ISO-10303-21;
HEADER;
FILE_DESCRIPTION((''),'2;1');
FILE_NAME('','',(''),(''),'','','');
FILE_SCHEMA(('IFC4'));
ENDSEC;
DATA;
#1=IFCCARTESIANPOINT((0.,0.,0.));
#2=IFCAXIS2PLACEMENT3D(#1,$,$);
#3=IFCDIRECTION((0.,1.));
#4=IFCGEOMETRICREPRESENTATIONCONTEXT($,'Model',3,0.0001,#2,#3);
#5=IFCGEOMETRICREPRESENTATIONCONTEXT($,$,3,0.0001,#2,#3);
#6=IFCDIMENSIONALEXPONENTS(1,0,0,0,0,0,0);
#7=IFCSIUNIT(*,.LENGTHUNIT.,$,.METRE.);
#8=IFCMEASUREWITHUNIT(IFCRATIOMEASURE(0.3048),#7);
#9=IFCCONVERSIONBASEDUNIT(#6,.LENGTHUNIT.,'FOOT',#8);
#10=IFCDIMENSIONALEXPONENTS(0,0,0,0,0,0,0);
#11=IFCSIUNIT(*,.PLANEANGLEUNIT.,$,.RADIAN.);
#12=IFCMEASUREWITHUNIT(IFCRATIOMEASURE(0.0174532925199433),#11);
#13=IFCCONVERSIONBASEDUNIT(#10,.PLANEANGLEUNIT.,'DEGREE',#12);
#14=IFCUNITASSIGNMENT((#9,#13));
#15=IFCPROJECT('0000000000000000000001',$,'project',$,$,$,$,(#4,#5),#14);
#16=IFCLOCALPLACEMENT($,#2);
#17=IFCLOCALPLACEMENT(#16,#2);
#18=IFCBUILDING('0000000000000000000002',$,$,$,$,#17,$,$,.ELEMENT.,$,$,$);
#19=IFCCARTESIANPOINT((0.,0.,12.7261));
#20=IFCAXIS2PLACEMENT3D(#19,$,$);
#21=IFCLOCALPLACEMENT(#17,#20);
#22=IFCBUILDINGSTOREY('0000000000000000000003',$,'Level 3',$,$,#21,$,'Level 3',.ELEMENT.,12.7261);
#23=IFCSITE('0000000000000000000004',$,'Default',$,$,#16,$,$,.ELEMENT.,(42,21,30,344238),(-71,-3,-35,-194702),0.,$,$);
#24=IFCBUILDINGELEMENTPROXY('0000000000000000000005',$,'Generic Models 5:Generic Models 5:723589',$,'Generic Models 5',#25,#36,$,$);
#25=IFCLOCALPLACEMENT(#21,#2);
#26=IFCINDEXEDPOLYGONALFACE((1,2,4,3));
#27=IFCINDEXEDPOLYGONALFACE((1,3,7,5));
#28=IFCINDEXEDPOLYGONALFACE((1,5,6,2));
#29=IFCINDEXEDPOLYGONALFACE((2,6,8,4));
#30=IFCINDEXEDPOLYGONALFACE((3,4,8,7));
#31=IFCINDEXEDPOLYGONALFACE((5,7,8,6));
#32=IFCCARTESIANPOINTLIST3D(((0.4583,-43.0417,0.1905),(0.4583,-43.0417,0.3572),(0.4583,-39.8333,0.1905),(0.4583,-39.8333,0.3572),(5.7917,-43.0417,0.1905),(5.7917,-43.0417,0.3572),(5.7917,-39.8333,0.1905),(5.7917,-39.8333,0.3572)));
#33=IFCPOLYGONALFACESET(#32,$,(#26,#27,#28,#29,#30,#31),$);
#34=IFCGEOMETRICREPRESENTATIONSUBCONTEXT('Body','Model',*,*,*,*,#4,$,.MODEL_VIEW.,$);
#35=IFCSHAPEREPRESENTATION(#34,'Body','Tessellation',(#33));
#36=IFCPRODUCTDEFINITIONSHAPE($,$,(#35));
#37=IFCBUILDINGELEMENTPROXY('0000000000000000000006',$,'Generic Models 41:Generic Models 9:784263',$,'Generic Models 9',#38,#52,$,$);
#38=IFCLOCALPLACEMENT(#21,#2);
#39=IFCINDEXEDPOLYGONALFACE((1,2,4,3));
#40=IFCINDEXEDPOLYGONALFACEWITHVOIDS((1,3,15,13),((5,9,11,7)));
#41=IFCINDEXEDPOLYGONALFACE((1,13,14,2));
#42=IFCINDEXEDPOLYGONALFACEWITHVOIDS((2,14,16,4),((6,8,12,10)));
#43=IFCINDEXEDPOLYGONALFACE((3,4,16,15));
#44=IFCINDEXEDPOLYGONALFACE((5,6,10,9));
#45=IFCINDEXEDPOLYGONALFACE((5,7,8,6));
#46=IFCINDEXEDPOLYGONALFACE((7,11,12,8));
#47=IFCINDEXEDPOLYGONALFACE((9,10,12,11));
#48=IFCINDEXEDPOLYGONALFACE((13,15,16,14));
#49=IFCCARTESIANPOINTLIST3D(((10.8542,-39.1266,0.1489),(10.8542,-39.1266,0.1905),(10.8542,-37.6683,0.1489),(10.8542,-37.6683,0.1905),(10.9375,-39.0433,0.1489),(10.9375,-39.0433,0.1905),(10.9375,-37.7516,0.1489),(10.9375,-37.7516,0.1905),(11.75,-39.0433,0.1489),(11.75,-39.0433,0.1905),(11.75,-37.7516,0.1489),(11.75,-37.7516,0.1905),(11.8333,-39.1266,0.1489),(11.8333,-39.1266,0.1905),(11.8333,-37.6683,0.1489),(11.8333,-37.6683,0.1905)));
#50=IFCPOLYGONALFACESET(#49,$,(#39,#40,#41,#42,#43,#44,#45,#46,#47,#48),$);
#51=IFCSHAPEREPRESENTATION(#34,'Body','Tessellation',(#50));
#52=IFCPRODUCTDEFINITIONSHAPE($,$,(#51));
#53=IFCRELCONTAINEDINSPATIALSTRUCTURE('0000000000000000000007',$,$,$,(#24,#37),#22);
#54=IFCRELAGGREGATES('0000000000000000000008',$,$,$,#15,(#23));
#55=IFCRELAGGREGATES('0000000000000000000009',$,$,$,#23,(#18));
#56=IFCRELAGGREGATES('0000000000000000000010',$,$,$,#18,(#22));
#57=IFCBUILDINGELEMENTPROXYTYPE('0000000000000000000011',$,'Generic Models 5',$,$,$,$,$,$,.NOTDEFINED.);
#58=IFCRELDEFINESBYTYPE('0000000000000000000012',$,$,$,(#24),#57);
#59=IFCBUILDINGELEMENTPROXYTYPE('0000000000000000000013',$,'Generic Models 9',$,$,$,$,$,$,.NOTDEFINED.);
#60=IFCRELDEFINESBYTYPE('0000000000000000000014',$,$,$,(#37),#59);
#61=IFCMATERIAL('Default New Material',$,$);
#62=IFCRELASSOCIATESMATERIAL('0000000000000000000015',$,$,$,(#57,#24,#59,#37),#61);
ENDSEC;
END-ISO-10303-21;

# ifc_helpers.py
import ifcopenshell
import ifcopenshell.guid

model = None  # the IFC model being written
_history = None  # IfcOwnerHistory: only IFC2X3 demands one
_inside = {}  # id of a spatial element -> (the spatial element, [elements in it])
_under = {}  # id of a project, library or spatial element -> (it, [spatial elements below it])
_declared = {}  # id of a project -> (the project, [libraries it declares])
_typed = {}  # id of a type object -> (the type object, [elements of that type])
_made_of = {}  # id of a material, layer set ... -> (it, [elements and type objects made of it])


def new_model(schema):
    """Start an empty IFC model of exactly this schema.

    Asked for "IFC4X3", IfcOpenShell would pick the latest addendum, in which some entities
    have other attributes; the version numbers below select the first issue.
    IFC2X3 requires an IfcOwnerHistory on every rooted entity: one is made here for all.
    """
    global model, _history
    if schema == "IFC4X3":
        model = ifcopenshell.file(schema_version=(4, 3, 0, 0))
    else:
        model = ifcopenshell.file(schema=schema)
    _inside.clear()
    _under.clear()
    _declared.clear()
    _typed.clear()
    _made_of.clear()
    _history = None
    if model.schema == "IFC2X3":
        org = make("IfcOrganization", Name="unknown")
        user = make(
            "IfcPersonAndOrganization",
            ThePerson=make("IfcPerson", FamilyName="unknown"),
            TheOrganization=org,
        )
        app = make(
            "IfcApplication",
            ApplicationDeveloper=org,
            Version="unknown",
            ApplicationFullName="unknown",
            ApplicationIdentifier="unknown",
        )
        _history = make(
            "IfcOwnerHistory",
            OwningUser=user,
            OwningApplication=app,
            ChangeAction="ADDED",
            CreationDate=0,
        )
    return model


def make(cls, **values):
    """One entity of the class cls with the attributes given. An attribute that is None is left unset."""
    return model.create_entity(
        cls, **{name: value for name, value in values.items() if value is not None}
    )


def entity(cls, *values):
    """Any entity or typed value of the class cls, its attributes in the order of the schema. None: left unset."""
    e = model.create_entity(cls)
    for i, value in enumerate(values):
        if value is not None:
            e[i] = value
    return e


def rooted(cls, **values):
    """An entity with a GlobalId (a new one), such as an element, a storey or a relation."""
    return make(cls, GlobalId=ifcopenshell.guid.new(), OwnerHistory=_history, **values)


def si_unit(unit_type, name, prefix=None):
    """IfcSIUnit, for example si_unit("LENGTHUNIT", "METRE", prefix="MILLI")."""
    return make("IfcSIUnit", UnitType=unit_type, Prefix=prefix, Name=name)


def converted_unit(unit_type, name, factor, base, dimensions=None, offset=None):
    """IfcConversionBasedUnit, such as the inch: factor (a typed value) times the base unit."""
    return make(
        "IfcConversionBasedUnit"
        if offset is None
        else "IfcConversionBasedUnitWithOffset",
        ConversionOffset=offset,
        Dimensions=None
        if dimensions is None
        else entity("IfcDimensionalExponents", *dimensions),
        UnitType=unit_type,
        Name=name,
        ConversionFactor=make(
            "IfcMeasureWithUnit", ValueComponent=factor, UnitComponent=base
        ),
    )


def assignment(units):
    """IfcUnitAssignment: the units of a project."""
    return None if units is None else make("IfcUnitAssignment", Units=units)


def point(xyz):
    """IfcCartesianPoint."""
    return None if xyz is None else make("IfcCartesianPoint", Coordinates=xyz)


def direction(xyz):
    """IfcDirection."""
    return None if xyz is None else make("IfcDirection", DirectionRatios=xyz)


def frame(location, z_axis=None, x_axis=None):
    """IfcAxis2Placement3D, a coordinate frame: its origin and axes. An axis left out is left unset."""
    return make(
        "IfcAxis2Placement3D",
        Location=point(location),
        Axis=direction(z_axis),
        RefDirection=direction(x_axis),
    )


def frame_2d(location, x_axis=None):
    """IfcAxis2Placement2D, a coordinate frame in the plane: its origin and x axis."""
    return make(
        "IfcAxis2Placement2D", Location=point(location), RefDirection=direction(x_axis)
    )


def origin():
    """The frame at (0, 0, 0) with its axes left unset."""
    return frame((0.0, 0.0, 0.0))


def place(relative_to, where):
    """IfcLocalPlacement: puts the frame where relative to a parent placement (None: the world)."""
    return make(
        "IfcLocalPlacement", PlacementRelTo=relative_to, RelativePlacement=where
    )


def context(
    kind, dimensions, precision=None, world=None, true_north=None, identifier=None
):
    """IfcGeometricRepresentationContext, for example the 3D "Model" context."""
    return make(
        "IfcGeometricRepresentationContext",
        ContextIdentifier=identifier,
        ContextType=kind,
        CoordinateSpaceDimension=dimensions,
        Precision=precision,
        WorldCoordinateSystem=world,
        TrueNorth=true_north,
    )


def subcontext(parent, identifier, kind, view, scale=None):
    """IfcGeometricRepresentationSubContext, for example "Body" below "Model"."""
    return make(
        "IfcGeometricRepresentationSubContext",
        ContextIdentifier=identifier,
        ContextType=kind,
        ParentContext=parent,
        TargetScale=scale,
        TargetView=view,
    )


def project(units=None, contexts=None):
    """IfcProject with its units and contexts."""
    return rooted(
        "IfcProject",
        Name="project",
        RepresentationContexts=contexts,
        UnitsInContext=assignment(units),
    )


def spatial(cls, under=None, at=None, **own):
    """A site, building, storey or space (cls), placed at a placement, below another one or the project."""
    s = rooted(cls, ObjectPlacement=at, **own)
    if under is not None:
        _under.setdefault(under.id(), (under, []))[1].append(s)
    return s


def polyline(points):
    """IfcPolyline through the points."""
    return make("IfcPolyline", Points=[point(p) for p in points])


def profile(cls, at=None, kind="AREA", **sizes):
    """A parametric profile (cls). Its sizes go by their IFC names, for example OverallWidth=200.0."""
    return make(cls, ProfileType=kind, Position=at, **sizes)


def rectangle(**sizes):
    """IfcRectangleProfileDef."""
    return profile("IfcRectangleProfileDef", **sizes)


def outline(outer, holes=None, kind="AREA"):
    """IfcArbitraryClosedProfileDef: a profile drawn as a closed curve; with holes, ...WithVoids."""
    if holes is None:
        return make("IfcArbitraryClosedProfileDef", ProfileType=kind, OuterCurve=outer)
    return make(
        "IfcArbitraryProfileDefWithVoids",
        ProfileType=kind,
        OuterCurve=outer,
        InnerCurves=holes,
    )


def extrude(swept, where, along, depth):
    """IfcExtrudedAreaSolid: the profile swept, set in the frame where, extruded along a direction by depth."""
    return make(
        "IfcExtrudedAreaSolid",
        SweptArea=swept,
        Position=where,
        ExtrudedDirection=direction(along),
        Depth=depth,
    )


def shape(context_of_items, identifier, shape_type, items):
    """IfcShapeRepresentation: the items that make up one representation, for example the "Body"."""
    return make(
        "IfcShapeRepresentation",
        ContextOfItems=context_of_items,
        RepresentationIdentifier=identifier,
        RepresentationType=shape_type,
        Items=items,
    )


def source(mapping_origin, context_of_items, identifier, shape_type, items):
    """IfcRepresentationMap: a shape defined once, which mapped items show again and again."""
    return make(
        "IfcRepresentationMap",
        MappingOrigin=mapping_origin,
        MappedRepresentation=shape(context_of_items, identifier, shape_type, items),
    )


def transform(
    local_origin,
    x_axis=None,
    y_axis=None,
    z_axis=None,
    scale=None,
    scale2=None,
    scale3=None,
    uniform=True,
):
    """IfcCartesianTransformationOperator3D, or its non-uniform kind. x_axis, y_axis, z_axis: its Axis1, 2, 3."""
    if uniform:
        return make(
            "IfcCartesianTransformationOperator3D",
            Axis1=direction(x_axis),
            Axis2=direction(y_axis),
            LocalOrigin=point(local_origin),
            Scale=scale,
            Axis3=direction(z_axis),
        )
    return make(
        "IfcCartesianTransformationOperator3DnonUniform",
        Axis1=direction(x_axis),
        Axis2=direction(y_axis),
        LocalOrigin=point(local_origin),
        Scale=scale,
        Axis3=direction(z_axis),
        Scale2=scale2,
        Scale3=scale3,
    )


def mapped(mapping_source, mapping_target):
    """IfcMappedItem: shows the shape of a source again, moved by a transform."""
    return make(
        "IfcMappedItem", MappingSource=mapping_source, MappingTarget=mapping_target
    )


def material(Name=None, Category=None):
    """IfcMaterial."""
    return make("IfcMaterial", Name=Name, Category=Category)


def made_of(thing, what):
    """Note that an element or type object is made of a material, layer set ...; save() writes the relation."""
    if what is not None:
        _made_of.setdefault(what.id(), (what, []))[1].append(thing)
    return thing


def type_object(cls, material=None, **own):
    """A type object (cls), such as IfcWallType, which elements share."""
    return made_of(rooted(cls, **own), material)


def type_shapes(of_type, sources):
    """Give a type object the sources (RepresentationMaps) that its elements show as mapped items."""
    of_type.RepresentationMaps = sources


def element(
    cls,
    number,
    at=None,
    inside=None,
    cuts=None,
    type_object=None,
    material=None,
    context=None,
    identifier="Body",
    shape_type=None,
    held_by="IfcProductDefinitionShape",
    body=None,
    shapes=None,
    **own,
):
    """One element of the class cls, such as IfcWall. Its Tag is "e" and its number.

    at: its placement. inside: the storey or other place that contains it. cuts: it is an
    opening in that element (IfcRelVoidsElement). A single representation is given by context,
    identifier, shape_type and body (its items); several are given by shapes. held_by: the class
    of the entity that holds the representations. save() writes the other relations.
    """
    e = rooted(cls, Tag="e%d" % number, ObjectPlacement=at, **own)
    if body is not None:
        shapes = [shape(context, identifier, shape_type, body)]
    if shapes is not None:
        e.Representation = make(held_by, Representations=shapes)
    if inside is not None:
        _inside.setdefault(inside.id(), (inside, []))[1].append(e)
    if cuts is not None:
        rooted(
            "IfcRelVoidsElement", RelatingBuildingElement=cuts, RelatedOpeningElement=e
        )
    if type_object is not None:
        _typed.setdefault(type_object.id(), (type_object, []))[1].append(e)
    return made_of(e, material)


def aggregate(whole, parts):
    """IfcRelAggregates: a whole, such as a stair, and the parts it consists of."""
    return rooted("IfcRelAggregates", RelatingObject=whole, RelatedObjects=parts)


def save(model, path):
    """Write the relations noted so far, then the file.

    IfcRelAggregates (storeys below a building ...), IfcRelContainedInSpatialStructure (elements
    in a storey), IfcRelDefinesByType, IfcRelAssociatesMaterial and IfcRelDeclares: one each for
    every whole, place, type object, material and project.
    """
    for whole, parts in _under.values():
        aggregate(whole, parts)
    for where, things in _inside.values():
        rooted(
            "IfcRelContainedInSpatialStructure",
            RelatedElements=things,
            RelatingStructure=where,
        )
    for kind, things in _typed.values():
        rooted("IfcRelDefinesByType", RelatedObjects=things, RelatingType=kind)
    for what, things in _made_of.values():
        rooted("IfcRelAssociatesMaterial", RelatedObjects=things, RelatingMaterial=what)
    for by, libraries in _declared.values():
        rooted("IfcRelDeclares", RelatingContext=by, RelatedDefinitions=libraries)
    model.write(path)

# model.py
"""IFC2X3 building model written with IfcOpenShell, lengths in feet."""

from ifc_helpers import new_model, entity, si_unit, converted_unit, direction, frame, frame_2d, origin, place, context, subcontext, project, spatial, polyline, rectangle, outline, extrude, source, transform, mapped, material, type_object, type_shapes, element, save


model = new_model("IFC2X3")

# Units and contexts
model_context = context("Model", 3, precision=0.0001, world=origin(), true_north=direction((0.0, 1.0)))
context_of_model = context(None, 3, precision=0.0001, world=origin(), true_north=direction((0.0, 1.0)))
body_context = subcontext(model_context, "Body", "Model", "MODEL_VIEW")
ifc_project = project(units=[converted_unit("LENGTHUNIT", "FOOT", entity("IfcRatioMeasure", 0.3048), si_unit("LENGTHUNIT", "METRE"), dimensions=[1, 0, 0, 0, 0, 0, 0]), converted_unit("PLANEANGLEUNIT", "DEGREE", entity("IfcRatioMeasure", 0.0174532925199433), si_unit("PLANEANGLEUNIT", "RADIAN"), dimensions=[0, 0, 0, 0, 0, 0, 0])], contexts=[model_context, context_of_model])

# Site, building, storey
site_placement = place(None, origin())
site = spatial("IfcSite", under=ifc_project, at=site_placement, Name="Default", CompositionType="ELEMENT", RefLatitude=(42, 21, 30, 344238), RefLongitude=(-71, -3, -35, -194702), RefElevation=0.0)
building_placement = place(site_placement, origin())
building = spatial("IfcBuilding", under=site, at=building_placement, CompositionType="ELEMENT")
storey_placement = place(building_placement, frame((0.0, 0.0, 12.7261)))
storey = spatial("IfcBuildingStorey", under=building, at=storey_placement, Name="Level 3", LongName="Level 3", CompositionType="ELEMENT", Elevation=12.7261)

# Shared definitions
ifc_material = material(Name="Default New Material")

# Building element proxies
building_element_proxy_type_1 = type_object("IfcBuildingElementProxyType", Name="Generic Models 5", PredefinedType="NOTDEFINED", material=ifc_material)
shared_shape_1 = source(origin(), body_context, "Body", "SweptSolid", [
    extrude(rectangle(XDim=3.2083, YDim=5.3333, at=frame_2d((0.0, 0.0), x_axis=(1.0, 0.0))), frame((2.6667, 1.6042, 0.0), z_axis=(0.0, 0.0, 1.0), x_axis=(0.0, -1.0, 0.0)), (0.0, 0.0, 1.0), 0.1667),
])
type_shapes(building_element_proxy_type_1, [shared_shape_1])
proxy_1_placement = place(storey_placement, frame((0.4583, -43.0417, 0.1905)))
element("IfcBuildingElementProxy", 1, at=proxy_1_placement, inside=storey, type_object=building_element_proxy_type_1, material=ifc_material, Name="Generic Models 5:Generic Models 5:723589", ObjectType="Generic Models 5", context=body_context, shape_type="MappedRepresentation", body=[
    mapped(shared_shape_1, transform((0.0, 0.0, 0.0), scale=1.0)),
])
building_element_proxy_type_2 = type_object("IfcBuildingElementProxyType", Name="Generic Models 9", PredefinedType="NOTDEFINED", material=ifc_material)
shared_shape_2 = source(origin(), body_context, "Body", "SweptSolid", [
    extrude(outline(polyline([(-0.7292, -0.4896), (0.7292, -0.4896), (0.7292, 0.4896), (-0.7292, 0.4896), (-0.7292, -0.4896)]), holes=[polyline([(-0.6458, -0.4063), (-0.6458, 0.4062), (0.6458, 0.4062), (0.6458, -0.4062), (-0.6458, -0.4063)])]), frame((0.4896, 0.7292, 0.0), z_axis=(0.0, 0.0, 1.0), x_axis=(0.0, -1.0, 0.0)), (0.0, 0.0, 1.0), 0.0417),
])
type_shapes(building_element_proxy_type_2, [shared_shape_2])
proxy_2_placement = place(storey_placement, frame((10.8542, -39.1266, 0.1489)))
element("IfcBuildingElementProxy", 2, at=proxy_2_placement, inside=storey, type_object=building_element_proxy_type_2, material=ifc_material, Name="Generic Models 41:Generic Models 9:784263", ObjectType="Generic Models 9", context=body_context, shape_type="MappedRepresentation", body=[
    mapped(shared_shape_2, transform((0.0, 0.0, 0.0), scale=1.0)),
])

save(model, "model.ifc")
